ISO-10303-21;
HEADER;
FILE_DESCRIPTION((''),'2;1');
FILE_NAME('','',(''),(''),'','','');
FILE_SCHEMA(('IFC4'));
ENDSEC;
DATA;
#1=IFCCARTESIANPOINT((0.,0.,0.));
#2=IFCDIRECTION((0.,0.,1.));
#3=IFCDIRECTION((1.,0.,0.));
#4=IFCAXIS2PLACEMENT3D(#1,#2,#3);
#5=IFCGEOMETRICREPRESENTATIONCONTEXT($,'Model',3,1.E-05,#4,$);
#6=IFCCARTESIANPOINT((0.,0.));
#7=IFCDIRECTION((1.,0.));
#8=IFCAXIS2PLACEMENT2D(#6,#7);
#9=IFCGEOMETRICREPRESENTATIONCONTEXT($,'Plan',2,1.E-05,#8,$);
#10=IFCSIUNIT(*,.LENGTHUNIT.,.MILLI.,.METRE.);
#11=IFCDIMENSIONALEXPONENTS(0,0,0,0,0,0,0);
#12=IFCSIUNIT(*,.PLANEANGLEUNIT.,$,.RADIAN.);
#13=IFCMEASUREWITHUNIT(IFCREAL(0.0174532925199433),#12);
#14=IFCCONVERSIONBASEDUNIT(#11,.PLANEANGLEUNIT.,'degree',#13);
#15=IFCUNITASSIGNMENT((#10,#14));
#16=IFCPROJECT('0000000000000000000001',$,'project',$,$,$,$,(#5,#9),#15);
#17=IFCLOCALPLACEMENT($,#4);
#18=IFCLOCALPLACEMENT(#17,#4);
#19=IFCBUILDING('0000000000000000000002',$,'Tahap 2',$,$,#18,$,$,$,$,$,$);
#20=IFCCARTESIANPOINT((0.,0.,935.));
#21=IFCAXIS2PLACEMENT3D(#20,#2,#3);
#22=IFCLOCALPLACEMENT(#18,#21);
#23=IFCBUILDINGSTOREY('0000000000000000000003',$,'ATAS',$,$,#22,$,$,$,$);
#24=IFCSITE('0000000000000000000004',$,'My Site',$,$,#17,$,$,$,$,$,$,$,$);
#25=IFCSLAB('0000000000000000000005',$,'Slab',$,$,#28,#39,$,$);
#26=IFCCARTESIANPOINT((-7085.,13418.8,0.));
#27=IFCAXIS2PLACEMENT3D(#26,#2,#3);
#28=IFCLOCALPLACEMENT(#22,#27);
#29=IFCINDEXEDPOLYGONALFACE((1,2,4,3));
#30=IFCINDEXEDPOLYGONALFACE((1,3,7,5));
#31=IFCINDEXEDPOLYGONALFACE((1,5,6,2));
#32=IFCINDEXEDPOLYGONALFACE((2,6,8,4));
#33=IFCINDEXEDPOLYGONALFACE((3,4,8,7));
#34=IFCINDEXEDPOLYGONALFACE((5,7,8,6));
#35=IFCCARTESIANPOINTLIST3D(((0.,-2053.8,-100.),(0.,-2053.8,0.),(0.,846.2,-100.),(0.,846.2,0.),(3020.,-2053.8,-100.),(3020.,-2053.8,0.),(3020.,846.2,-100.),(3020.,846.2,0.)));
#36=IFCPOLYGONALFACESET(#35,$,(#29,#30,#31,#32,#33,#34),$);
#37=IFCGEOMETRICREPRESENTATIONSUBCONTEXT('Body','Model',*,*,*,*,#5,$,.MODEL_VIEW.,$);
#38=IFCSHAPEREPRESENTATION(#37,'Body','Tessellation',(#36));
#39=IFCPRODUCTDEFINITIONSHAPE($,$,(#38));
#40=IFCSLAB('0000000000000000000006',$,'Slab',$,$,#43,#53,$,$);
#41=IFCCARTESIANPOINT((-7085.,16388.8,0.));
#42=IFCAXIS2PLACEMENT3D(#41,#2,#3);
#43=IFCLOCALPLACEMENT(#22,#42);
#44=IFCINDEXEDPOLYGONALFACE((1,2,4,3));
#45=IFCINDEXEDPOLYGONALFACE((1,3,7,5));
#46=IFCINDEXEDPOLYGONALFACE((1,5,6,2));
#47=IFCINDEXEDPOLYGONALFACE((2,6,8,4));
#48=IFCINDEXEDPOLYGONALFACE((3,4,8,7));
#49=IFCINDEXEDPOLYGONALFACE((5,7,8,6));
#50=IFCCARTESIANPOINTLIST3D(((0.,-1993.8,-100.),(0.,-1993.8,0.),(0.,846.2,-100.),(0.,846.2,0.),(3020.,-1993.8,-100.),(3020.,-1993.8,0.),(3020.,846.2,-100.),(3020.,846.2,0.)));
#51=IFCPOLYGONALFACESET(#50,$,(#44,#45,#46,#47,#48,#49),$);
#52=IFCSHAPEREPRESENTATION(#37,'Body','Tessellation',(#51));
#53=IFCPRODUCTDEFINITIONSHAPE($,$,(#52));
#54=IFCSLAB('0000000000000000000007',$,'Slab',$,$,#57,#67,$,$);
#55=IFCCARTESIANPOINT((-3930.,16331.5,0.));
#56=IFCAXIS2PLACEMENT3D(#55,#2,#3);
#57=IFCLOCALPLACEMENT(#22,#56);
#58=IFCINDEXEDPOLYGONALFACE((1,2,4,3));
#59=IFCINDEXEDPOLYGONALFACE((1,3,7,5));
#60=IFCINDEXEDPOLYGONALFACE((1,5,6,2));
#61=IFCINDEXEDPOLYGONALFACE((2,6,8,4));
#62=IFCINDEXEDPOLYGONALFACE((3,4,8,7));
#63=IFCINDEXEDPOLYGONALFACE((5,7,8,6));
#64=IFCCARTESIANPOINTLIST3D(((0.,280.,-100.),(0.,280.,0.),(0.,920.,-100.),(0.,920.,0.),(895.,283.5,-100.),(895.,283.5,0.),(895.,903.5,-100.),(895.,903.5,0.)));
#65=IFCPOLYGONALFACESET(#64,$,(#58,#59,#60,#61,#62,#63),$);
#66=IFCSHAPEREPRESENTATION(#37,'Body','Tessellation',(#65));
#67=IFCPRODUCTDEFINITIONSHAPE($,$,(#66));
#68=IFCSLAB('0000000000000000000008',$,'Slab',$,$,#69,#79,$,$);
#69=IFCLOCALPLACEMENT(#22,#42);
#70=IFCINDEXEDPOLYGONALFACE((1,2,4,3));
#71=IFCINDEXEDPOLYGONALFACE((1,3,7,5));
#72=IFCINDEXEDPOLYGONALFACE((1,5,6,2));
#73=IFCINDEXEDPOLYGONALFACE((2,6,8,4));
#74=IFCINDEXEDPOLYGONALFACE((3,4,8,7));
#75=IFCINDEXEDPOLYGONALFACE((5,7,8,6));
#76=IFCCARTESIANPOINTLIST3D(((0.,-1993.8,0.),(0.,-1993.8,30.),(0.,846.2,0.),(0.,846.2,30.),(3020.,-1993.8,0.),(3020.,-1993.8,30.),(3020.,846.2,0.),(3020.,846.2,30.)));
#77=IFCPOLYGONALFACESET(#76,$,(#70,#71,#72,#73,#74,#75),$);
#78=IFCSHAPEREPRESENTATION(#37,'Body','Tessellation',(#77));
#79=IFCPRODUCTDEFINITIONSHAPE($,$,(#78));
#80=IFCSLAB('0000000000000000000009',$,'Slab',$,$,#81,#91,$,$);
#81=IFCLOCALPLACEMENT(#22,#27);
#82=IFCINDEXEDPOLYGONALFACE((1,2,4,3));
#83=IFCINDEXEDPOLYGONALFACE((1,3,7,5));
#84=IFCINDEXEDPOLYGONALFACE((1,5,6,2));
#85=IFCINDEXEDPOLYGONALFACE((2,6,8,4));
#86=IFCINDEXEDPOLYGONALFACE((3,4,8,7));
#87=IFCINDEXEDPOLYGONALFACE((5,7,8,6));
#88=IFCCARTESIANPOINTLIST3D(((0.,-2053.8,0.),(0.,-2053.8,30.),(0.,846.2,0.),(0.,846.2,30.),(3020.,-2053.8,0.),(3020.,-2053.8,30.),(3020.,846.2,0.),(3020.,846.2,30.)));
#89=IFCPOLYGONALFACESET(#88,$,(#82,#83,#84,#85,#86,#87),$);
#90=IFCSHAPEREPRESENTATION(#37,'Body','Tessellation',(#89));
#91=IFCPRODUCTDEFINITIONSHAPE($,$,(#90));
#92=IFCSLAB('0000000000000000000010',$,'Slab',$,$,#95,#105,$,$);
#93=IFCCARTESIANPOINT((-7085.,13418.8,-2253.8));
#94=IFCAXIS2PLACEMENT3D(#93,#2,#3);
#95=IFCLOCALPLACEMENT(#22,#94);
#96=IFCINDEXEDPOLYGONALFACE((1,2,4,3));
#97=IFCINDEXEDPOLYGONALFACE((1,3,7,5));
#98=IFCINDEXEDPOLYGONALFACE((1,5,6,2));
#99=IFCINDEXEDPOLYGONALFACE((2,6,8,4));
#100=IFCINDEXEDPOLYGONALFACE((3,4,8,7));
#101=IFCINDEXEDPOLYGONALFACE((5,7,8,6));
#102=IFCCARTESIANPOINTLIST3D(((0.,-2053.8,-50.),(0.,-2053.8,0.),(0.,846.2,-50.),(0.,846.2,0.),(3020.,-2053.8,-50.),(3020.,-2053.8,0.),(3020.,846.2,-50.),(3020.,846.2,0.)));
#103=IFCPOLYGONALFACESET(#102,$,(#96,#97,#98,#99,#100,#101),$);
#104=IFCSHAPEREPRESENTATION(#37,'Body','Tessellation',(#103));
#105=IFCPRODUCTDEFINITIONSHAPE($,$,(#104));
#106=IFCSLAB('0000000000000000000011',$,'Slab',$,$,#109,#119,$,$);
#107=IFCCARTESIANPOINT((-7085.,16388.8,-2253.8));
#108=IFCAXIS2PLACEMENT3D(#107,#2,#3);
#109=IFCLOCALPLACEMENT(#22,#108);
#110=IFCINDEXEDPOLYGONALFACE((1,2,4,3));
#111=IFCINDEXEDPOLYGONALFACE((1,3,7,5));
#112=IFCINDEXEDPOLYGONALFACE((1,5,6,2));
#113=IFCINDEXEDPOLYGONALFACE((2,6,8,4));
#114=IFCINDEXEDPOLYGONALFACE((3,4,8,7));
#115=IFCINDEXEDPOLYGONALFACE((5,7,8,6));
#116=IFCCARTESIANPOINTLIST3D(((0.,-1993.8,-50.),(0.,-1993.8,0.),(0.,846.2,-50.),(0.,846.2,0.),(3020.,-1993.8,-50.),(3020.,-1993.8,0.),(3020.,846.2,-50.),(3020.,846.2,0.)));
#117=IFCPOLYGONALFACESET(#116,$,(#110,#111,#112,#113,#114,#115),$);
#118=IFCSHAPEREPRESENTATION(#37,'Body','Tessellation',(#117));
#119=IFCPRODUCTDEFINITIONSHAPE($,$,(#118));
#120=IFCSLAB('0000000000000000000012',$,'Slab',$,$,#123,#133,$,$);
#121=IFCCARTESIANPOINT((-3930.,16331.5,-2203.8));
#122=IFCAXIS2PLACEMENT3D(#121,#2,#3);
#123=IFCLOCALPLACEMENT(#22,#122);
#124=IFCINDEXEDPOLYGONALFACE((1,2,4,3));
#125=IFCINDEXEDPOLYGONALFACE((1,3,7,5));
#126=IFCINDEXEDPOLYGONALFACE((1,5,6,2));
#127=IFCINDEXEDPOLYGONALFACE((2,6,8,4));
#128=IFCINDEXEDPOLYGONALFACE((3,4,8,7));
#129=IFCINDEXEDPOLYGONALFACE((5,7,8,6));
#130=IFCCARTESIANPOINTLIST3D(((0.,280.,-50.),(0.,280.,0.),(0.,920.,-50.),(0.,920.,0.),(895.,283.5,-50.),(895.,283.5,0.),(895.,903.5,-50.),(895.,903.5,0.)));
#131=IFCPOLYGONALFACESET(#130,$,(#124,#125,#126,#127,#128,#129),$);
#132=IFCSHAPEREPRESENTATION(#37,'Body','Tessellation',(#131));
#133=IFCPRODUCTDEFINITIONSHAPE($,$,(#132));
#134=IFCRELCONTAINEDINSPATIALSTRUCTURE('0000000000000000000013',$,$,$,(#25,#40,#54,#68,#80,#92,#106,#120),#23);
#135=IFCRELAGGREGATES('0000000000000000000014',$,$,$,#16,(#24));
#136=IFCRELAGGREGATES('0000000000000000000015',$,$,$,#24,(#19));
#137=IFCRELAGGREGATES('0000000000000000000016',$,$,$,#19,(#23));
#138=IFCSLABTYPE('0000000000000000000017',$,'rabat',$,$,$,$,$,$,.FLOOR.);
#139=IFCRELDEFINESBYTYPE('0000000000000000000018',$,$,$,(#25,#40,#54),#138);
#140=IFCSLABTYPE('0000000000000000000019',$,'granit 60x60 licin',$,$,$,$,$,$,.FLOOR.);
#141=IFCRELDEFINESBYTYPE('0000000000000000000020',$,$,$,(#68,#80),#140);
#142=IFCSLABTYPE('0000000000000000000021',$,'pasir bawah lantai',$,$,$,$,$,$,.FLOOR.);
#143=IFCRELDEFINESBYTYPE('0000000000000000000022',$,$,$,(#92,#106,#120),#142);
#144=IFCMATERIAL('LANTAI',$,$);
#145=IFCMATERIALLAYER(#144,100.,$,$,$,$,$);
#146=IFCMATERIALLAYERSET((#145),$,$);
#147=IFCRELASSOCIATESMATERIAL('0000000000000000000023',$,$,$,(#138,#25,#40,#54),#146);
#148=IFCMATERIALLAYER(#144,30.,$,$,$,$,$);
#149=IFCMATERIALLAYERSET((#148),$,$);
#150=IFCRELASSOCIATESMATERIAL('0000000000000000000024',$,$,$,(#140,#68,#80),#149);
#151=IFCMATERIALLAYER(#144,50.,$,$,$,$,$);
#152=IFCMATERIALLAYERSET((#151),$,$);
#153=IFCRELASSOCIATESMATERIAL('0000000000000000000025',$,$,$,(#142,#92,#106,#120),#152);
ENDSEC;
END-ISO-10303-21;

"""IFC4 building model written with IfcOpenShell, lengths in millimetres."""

from ifc_helpers import new_model, entity, si_unit, converted_unit, frame, origin_with_axes, origin_2d_with_axis, place, context, subcontext, project, spatial, indexed_curve, outline, extrude, material, layer, layer_set, layer_usage, type_object, element, save


model = new_model("IFC4")

# Units and contexts
model_context = context("Model", 3, precision=1e-05, world=origin_with_axes())
plan_context = context("Plan", 2, precision=1e-05, world=origin_2d_with_axis())
body_context_1 = subcontext(model_context, "Body", "Model", "MODEL_VIEW")
ifc_project = project(units=[si_unit("LENGTHUNIT", "METRE", prefix="MILLI"), converted_unit("PLANEANGLEUNIT", "degree", entity("IfcReal", 0.0174532925199433), si_unit("PLANEANGLEUNIT", "RADIAN"), dimensions=[0, 0, 0, 0, 0, 0, 0])], contexts=[model_context, plan_context])

# Site, building, storey
site_placement = place(None, origin_with_axes())
site = spatial("IfcSite", under=ifc_project, at=site_placement, Name="My Site")
building_placement = place(site_placement, origin_with_axes())
building = spatial("IfcBuilding", under=site, at=building_placement, Name="Tahap 2")
storey_placement = place(building_placement, frame((0.0, 0.0, 935.0), z_axis=(0.0, 0.0, 1.0), x_axis=(1.0, 0.0, 0.0)))
storey = spatial("IfcBuildingStorey", under=building, at=storey_placement, Name="ATAS")

# Slabs
ifc_material_1 = material(Name="LANTAI")
ifc_layer_1 = layer(ifc_material_1, 100.0)
ifc_layer_set_1 = layer_set([ifc_layer_1])
ifc_layer_usage_1 = layer_usage(ifc_layer_set_1, "AXIS3", "NEGATIVE", 0.0)
slab_type_1 = type_object("IfcSlabType", Name="rabat", PredefinedType="FLOOR", material=ifc_layer_set_1)
slab_1_placement = place(storey_placement, frame((-7085.0, 13418.8, 0.0), z_axis=(0.0, 0.0, 1.0), x_axis=(1.0, 0.0, 0.0)))
element("IfcSlab", 1, at=slab_1_placement, inside=storey, type_object=slab_type_1, material=ifc_layer_usage_1, Name="Slab", context=body_context_1, shape_type="SweptSolid", body=[
    extrude(outline(indexed_curve([(0.0, 846.2), (3020.0, 846.2), (3020.0, -2053.8), (0.0, -2053.8), (0.0, 846.2)])), None, (0.0, 0.0, -1.0), 100.0),
])
ifc_layer_usage_2 = layer_usage(ifc_layer_set_1, "AXIS3", "NEGATIVE", 0.0)
slab_2_placement = place(storey_placement, frame((-7085.0, 16388.8, 0.0), z_axis=(0.0, 0.0, 1.0), x_axis=(1.0, 0.0, 0.0)))
element("IfcSlab", 2, at=slab_2_placement, inside=storey, type_object=slab_type_1, material=ifc_layer_usage_2, Name="Slab", context=body_context_1, shape_type="SweptSolid", body=[
    extrude(outline(indexed_curve([(0.0, 846.2), (3020.0, 846.2), (3020.0, -1993.8), (0.0, -1993.8), (0.0, 846.2)])), None, (0.0, 0.0, -1.0), 100.0),
])
ifc_layer_usage_3 = layer_usage(ifc_layer_set_1, "AXIS3", "NEGATIVE", 0.0)
slab_3_placement = place(storey_placement, frame((-3930.0, 16331.5, 0.0), z_axis=(0.0, 0.0, 1.0), x_axis=(1.0, 0.0, 0.0)))
element("IfcSlab", 3, at=slab_3_placement, inside=storey, type_object=slab_type_1, material=ifc_layer_usage_3, Name="Slab", context=body_context_1, shape_type="SweptSolid", body=[
    extrude(outline(indexed_curve([(895.0, 283.5), (895.0, 903.5), (0.0, 920.0), (0.0, 280.0), (895.0, 283.5)])), None, (0.0, 0.0, -1.0), 100.0),
])
ifc_layer_2 = layer(ifc_material_1, 30.0)
ifc_layer_set_2 = layer_set([ifc_layer_2])
ifc_layer_usage_4 = layer_usage(ifc_layer_set_2, "AXIS3", "POSITIVE", 0.0)
slab_type_2 = type_object("IfcSlabType", Name="granit 60x60 licin", PredefinedType="FLOOR", material=ifc_layer_set_2)
slab_4_placement = place(storey_placement, frame((-7085.0, 16388.8, 0.0), z_axis=(0.0, 0.0, 1.0), x_axis=(1.0, 0.0, 0.0)))
element("IfcSlab", 4, at=slab_4_placement, inside=storey, type_object=slab_type_2, material=ifc_layer_usage_4, Name="Slab", context=body_context_1, shape_type="SweptSolid", body=[
    extrude(outline(indexed_curve([(0.0, 846.2), (3020.0, 846.2), (3020.0, -1993.8), (0.0, -1993.8), (0.0, 846.2)])), None, (0.0, 0.0, 1.0), 30.0),
])
ifc_layer_usage_5 = layer_usage(ifc_layer_set_2, "AXIS3", "POSITIVE", 0.0)
slab_5_placement = place(storey_placement, frame((-7085.0, 13418.8, 0.0), z_axis=(0.0, 0.0, 1.0), x_axis=(1.0, 0.0, 0.0)))
element("IfcSlab", 5, at=slab_5_placement, inside=storey, type_object=slab_type_2, material=ifc_layer_usage_5, Name="Slab", context=body_context_1, shape_type="SweptSolid", body=[
    extrude(outline(indexed_curve([(0.0, 846.2), (3020.0, 846.2), (3020.0, -2053.8), (0.0, -2053.8), (0.0, 846.2)])), None, (0.0, 0.0, 1.0), 30.0),
])
ifc_layer_3 = layer(ifc_material_1, 50.0)
ifc_layer_set_3 = layer_set([ifc_layer_3])
ifc_layer_usage_6 = layer_usage(ifc_layer_set_3, "AXIS3", "POSITIVE", -50.0)
slab_type_3 = type_object("IfcSlabType", Name="pasir bawah lantai", PredefinedType="FLOOR", material=ifc_layer_set_3)
slab_6_placement = place(storey_placement, frame((-7085.0, 13418.8, -2253.8), z_axis=(0.0, 0.0, 1.0), x_axis=(1.0, 0.0, 0.0)))
element("IfcSlab", 6, at=slab_6_placement, inside=storey, type_object=slab_type_3, material=ifc_layer_usage_6, Name="Slab", context=body_context_1, shape_type="SweptSolid", body=[
    extrude(outline(indexed_curve([(0.0, 846.2), (3020.0, 846.2), (3020.0, -2053.8), (0.0, -2053.8), (0.0, 846.2)])), frame((0.0, 0.0, -50.0), z_axis=(0.0, 0.0, 1.0), x_axis=(1.0, 0.0, 0.0)), (0.0, 0.0, 1.0), 50.0),
])
ifc_layer_usage_7 = layer_usage(ifc_layer_set_3, "AXIS3", "POSITIVE", -50.0)
slab_7_placement = place(storey_placement, frame((-7085.0, 16388.8, -2253.8), z_axis=(0.0, 0.0, 1.0), x_axis=(1.0, 0.0, 0.0)))
element("IfcSlab", 7, at=slab_7_placement, inside=storey, type_object=slab_type_3, material=ifc_layer_usage_7, Name="Slab", context=body_context_1, shape_type="SweptSolid", body=[
    extrude(outline(indexed_curve([(0.0, 846.2), (3020.0, 846.2), (3020.0, -1993.8), (0.0, -1993.8), (0.0, 846.2)])), frame((0.0, 0.0, -50.0), z_axis=(0.0, 0.0, 1.0), x_axis=(1.0, 0.0, 0.0)), (0.0, 0.0, 1.0), 50.0),
])
ifc_layer_usage_8 = layer_usage(ifc_layer_set_3, "AXIS3", "POSITIVE", -50.0)
slab_8_placement = place(storey_placement, frame((-3930.0, 16331.5, -2203.8), z_axis=(0.0, 0.0, 1.0), x_axis=(1.0, 0.0, 0.0)))
element("IfcSlab", 8, at=slab_8_placement, inside=storey, type_object=slab_type_3, material=ifc_layer_usage_8, Name="Slab", context=body_context_1, shape_type="SweptSolid", body=[
    extrude(outline(indexed_curve([(895.0, 283.5), (895.0, 903.5), (0.0, 920.0), (0.0, 280.0), (895.0, 283.5)])), frame((0.0, 0.0, -50.0), z_axis=(0.0, 0.0, 1.0), x_axis=(1.0, 0.0, 0.0)), (0.0, 0.0, 1.0), 50.0),
])

save(model, "model.ifc")
